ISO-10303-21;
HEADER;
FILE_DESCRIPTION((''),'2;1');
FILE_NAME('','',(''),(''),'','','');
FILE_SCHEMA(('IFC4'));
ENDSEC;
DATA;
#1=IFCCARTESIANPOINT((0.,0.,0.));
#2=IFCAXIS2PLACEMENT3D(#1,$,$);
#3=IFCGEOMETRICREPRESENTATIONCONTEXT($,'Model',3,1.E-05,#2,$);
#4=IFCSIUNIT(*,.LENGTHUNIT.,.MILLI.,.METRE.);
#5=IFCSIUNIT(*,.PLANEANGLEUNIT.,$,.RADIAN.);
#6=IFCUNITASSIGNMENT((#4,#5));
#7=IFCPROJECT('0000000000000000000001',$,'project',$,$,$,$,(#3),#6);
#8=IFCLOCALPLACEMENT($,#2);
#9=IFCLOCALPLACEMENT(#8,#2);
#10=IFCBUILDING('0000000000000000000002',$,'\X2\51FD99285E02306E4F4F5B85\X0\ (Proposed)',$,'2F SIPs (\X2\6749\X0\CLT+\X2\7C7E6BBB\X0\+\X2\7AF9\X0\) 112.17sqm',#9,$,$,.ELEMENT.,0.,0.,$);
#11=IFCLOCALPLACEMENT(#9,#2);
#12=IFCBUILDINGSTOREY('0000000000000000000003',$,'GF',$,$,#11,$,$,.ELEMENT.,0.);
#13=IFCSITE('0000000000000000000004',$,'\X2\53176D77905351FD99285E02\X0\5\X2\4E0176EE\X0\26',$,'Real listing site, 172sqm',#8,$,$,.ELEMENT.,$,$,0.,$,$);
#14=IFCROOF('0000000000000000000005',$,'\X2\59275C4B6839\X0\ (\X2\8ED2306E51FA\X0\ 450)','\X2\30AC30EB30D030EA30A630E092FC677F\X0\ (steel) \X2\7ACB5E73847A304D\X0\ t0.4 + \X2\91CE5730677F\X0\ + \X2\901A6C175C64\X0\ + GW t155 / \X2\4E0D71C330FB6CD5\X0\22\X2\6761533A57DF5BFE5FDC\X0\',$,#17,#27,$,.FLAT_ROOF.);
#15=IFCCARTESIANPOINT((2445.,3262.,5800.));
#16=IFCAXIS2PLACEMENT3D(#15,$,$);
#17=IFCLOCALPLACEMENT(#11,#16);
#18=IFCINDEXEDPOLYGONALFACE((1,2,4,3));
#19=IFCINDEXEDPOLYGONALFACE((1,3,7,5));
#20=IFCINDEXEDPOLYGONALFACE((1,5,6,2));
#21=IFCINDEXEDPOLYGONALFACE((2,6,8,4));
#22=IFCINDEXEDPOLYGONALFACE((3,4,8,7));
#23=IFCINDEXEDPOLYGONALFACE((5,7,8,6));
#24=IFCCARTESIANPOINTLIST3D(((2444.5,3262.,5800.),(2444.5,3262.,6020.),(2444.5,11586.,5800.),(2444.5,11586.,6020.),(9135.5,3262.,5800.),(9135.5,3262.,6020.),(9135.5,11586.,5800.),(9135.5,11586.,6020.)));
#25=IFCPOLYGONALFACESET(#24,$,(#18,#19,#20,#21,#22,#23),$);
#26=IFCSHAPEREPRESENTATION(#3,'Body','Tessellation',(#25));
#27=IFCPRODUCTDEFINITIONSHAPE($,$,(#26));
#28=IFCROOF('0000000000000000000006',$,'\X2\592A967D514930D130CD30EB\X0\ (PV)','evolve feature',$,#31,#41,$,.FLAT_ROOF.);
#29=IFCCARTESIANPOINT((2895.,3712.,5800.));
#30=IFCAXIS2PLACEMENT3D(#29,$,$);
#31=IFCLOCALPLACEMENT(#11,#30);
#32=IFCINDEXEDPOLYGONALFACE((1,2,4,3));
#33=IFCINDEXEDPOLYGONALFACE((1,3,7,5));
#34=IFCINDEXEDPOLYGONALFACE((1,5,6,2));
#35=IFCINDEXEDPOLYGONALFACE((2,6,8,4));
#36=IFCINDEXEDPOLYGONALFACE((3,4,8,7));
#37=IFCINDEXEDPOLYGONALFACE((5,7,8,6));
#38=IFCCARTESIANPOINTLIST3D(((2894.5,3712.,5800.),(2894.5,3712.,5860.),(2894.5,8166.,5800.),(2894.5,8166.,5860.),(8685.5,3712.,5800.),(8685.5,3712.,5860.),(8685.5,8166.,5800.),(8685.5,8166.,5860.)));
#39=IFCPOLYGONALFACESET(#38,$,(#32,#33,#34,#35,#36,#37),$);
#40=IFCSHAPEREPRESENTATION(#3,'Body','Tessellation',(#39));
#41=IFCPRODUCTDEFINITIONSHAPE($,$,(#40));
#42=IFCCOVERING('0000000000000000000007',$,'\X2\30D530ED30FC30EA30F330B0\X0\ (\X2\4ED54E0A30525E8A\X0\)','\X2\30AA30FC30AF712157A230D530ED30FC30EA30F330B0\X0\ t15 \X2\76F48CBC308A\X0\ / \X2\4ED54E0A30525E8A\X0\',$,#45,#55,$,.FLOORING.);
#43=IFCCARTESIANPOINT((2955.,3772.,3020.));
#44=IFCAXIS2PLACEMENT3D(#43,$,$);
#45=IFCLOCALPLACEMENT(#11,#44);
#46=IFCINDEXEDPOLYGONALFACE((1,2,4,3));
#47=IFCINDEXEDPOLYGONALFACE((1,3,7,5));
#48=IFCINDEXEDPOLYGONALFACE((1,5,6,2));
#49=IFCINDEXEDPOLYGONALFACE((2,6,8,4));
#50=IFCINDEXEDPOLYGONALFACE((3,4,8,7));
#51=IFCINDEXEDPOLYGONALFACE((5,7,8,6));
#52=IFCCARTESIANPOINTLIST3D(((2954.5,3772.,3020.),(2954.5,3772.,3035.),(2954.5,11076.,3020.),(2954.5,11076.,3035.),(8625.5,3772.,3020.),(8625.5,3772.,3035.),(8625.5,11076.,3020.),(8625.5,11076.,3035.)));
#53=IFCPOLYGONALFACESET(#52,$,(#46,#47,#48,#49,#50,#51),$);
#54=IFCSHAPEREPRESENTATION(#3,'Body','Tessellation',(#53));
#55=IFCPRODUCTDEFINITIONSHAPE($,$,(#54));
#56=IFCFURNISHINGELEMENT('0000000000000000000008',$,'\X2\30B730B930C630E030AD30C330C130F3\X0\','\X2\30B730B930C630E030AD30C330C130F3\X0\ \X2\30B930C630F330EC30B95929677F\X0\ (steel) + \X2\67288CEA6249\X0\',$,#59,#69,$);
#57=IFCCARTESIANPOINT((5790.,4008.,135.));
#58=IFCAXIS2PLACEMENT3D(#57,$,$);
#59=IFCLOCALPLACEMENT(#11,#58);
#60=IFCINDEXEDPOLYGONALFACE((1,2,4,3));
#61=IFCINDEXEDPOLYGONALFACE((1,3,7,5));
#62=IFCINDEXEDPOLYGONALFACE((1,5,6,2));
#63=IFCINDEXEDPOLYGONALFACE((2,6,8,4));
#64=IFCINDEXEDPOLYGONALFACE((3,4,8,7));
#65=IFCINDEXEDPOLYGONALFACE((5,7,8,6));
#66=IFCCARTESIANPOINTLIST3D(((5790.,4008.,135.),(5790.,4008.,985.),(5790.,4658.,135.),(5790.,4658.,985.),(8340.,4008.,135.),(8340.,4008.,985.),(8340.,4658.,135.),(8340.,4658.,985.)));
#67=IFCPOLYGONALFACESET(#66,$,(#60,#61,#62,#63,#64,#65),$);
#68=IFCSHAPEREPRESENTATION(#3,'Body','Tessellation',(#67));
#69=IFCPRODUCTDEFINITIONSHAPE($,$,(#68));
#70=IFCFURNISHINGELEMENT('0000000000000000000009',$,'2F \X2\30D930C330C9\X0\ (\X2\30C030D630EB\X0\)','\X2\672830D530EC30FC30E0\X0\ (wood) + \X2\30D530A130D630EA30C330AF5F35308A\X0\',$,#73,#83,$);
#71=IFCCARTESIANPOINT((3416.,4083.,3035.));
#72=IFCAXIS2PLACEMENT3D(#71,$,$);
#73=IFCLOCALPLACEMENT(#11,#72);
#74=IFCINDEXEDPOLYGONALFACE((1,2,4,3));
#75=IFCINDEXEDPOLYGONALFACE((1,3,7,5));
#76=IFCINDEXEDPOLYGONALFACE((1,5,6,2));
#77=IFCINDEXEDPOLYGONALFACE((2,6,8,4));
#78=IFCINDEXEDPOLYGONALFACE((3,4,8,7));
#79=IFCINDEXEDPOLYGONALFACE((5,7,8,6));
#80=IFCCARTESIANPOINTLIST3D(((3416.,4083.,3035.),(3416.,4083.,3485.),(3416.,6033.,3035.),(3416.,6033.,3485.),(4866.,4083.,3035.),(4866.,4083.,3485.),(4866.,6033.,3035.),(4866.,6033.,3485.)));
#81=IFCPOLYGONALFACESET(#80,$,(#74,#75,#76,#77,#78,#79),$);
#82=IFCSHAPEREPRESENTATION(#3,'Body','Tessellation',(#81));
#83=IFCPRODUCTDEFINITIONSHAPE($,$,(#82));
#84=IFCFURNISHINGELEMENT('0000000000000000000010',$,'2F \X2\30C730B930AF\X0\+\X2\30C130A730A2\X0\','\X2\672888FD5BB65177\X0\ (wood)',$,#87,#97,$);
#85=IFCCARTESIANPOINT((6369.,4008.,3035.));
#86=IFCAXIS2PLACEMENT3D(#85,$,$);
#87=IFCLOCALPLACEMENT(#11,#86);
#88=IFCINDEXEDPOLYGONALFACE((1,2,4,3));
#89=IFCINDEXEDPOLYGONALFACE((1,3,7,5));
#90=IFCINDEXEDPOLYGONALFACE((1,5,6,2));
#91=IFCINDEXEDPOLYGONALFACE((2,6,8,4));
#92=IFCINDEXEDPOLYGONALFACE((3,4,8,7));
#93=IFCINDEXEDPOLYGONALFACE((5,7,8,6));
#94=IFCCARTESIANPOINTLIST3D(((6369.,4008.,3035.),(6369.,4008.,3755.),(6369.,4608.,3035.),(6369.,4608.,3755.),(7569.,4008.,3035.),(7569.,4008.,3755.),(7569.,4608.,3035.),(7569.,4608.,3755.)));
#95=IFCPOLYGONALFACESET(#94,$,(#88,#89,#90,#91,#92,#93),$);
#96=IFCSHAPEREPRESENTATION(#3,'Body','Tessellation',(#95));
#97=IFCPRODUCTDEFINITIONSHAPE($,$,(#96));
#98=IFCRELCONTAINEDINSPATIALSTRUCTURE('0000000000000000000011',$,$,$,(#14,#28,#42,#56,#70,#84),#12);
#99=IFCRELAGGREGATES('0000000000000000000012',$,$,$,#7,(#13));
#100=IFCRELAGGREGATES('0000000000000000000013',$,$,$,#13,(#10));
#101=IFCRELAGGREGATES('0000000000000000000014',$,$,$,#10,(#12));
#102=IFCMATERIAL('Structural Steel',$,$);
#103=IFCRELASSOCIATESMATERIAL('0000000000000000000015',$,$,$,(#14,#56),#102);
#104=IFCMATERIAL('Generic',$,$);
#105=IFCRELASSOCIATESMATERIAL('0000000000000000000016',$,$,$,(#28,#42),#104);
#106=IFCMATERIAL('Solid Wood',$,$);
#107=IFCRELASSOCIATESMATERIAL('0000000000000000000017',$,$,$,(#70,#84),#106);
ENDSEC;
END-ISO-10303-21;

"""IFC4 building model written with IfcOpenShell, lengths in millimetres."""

from ifc_helpers import new_model, si_unit, frame, frame_2d, origin, place, context, project, spatial, rectangle, extrude, material, element, save


model = new_model("IFC4")

# Units and contexts
model_context = context("Model", 3, precision=1e-05, world=origin())
ifc_project = project(units=[si_unit("LENGTHUNIT", "METRE", prefix="MILLI"), si_unit("PLANEANGLEUNIT", "RADIAN")], contexts=[model_context])

# Site, building, storey
site_placement = place(None, origin())
site = spatial("IfcSite", under=ifc_project, at=site_placement, Name="北海道函館市5丁目26", ObjectType="Real listing site, 172sqm", CompositionType="ELEMENT", RefElevation=0.0)
building_placement = place(site_placement, origin())
building = spatial("IfcBuilding", under=site, at=building_placement, Name="函館市の住宅 (Proposed)", ObjectType="2F SIPs (杉CLT+籾殻+竹) 112.17sqm", CompositionType="ELEMENT", ElevationOfRefHeight=0.0, ElevationOfTerrain=0.0)
storey_placement = place(building_placement, origin())
storey = spatial("IfcBuildingStorey", under=building, at=storey_placement, Name="GF", CompositionType="ELEMENT", Elevation=0.0)

# Shared definitions
ifc_material_1 = material(Name="Solid Wood")

# Shared definitions
ifc_material_2 = material(Name="Generic")

# Roofs
ifc_material_3 = material(Name="Structural Steel")
roof_1_placement = place(storey_placement, frame((2445.0, 3262.0, 5800.0)))
element("IfcRoof", 1, at=roof_1_placement, inside=storey, material=ifc_material_3, Name="大屋根 (軒の出 450)", Description="ガルバリウム鋼板 (steel) 立平葺き t0.4 + 野地板 + 通気層 + GW t155 / 不燃・法22条区域対応", PredefinedType="FLAT_ROOF", context=model_context, shape_type="SweptSolid", body=[
    extrude(rectangle(XDim=6691.0, YDim=8324.0, at=frame_2d((3345.0, 4162.0))), frame((2445.0, 3262.0, 5800.0)), (0.0, 0.0, 1.0), 220.0),
])
roof_2_placement = place(storey_placement, frame((2895.0, 3712.0, 5800.0)))
element("IfcRoof", 2, at=roof_2_placement, inside=storey, material=ifc_material_2, Name="太陽光パネル (PV)", Description="evolve feature", PredefinedType="FLAT_ROOF", context=model_context, shape_type="SweptSolid", body=[
    extrude(rectangle(XDim=5791.0, YDim=4454.0, at=frame_2d((2895.0, 2227.0))), frame((2895.0, 3712.0, 5800.0)), (0.0, 0.0, 1.0), 60.0),
])

# Covering
covering_placement = place(storey_placement, frame((2955.0, 3772.0, 3020.0)))
element("IfcCovering", 3, at=covering_placement, inside=storey, material=ifc_material_2, Name="フローリング (仕上げ床)", Description="オーク無垢フローリング t15 直貼り / 仕上げ床", PredefinedType="FLOORING", context=model_context, shape_type="SweptSolid", body=[
    extrude(rectangle(XDim=5671.0, YDim=7304.0, at=frame_2d((2835.0, 3652.0))), frame((2955.0, 3772.0, 3020.0)), (0.0, 0.0, 1.0), 15.0),
])

# Furnishing elements
furnishing_1_placement = place(storey_placement, frame((5790.0, 4008.0, 135.0)))
element("IfcFurnishingElement", 4, at=furnishing_1_placement, inside=storey, material=ifc_material_3, Name="システムキッチン", Description="システムキッチン ステンレス天板 (steel) + 木質扉", context=model_context, shape_type="SweptSolid", body=[
    extrude(rectangle(XDim=2550.0, YDim=650.0, at=frame_2d((1275.0, 325.0))), frame((5790.0, 4008.0, 135.0)), (0.0, 0.0, 1.0), 850.0),
])
furnishing_2_placement = place(storey_placement, frame((3416.0, 4083.0, 3035.0)))
element("IfcFurnishingElement", 5, at=furnishing_2_placement, inside=storey, material=ifc_material_1, Name="2F ベッド (ダブル)", Description="木フレーム (wood) + ファブリック張り", context=model_context, shape_type="SweptSolid", body=[
    extrude(rectangle(XDim=1450.0, YDim=1950.0, at=frame_2d((725.0, 975.0))), frame((3416.0, 4083.0, 3035.0)), (0.0, 0.0, 1.0), 450.0),
])
furnishing_3_placement = place(storey_placement, frame((6369.0, 4008.0, 3035.0)))
element("IfcFurnishingElement", 6, at=furnishing_3_placement, inside=storey, material=ifc_material_1, Name="2F デスク+チェア", Description="木製家具 (wood)", context=model_context, shape_type="SweptSolid", body=[
    extrude(rectangle(XDim=1200.0, YDim=600.0, at=frame_2d((600.0, 300.0))), frame((6369.0, 4008.0, 3035.0)), (0.0, 0.0, 1.0), 720.0),
])

save(model, "model.ifc")
